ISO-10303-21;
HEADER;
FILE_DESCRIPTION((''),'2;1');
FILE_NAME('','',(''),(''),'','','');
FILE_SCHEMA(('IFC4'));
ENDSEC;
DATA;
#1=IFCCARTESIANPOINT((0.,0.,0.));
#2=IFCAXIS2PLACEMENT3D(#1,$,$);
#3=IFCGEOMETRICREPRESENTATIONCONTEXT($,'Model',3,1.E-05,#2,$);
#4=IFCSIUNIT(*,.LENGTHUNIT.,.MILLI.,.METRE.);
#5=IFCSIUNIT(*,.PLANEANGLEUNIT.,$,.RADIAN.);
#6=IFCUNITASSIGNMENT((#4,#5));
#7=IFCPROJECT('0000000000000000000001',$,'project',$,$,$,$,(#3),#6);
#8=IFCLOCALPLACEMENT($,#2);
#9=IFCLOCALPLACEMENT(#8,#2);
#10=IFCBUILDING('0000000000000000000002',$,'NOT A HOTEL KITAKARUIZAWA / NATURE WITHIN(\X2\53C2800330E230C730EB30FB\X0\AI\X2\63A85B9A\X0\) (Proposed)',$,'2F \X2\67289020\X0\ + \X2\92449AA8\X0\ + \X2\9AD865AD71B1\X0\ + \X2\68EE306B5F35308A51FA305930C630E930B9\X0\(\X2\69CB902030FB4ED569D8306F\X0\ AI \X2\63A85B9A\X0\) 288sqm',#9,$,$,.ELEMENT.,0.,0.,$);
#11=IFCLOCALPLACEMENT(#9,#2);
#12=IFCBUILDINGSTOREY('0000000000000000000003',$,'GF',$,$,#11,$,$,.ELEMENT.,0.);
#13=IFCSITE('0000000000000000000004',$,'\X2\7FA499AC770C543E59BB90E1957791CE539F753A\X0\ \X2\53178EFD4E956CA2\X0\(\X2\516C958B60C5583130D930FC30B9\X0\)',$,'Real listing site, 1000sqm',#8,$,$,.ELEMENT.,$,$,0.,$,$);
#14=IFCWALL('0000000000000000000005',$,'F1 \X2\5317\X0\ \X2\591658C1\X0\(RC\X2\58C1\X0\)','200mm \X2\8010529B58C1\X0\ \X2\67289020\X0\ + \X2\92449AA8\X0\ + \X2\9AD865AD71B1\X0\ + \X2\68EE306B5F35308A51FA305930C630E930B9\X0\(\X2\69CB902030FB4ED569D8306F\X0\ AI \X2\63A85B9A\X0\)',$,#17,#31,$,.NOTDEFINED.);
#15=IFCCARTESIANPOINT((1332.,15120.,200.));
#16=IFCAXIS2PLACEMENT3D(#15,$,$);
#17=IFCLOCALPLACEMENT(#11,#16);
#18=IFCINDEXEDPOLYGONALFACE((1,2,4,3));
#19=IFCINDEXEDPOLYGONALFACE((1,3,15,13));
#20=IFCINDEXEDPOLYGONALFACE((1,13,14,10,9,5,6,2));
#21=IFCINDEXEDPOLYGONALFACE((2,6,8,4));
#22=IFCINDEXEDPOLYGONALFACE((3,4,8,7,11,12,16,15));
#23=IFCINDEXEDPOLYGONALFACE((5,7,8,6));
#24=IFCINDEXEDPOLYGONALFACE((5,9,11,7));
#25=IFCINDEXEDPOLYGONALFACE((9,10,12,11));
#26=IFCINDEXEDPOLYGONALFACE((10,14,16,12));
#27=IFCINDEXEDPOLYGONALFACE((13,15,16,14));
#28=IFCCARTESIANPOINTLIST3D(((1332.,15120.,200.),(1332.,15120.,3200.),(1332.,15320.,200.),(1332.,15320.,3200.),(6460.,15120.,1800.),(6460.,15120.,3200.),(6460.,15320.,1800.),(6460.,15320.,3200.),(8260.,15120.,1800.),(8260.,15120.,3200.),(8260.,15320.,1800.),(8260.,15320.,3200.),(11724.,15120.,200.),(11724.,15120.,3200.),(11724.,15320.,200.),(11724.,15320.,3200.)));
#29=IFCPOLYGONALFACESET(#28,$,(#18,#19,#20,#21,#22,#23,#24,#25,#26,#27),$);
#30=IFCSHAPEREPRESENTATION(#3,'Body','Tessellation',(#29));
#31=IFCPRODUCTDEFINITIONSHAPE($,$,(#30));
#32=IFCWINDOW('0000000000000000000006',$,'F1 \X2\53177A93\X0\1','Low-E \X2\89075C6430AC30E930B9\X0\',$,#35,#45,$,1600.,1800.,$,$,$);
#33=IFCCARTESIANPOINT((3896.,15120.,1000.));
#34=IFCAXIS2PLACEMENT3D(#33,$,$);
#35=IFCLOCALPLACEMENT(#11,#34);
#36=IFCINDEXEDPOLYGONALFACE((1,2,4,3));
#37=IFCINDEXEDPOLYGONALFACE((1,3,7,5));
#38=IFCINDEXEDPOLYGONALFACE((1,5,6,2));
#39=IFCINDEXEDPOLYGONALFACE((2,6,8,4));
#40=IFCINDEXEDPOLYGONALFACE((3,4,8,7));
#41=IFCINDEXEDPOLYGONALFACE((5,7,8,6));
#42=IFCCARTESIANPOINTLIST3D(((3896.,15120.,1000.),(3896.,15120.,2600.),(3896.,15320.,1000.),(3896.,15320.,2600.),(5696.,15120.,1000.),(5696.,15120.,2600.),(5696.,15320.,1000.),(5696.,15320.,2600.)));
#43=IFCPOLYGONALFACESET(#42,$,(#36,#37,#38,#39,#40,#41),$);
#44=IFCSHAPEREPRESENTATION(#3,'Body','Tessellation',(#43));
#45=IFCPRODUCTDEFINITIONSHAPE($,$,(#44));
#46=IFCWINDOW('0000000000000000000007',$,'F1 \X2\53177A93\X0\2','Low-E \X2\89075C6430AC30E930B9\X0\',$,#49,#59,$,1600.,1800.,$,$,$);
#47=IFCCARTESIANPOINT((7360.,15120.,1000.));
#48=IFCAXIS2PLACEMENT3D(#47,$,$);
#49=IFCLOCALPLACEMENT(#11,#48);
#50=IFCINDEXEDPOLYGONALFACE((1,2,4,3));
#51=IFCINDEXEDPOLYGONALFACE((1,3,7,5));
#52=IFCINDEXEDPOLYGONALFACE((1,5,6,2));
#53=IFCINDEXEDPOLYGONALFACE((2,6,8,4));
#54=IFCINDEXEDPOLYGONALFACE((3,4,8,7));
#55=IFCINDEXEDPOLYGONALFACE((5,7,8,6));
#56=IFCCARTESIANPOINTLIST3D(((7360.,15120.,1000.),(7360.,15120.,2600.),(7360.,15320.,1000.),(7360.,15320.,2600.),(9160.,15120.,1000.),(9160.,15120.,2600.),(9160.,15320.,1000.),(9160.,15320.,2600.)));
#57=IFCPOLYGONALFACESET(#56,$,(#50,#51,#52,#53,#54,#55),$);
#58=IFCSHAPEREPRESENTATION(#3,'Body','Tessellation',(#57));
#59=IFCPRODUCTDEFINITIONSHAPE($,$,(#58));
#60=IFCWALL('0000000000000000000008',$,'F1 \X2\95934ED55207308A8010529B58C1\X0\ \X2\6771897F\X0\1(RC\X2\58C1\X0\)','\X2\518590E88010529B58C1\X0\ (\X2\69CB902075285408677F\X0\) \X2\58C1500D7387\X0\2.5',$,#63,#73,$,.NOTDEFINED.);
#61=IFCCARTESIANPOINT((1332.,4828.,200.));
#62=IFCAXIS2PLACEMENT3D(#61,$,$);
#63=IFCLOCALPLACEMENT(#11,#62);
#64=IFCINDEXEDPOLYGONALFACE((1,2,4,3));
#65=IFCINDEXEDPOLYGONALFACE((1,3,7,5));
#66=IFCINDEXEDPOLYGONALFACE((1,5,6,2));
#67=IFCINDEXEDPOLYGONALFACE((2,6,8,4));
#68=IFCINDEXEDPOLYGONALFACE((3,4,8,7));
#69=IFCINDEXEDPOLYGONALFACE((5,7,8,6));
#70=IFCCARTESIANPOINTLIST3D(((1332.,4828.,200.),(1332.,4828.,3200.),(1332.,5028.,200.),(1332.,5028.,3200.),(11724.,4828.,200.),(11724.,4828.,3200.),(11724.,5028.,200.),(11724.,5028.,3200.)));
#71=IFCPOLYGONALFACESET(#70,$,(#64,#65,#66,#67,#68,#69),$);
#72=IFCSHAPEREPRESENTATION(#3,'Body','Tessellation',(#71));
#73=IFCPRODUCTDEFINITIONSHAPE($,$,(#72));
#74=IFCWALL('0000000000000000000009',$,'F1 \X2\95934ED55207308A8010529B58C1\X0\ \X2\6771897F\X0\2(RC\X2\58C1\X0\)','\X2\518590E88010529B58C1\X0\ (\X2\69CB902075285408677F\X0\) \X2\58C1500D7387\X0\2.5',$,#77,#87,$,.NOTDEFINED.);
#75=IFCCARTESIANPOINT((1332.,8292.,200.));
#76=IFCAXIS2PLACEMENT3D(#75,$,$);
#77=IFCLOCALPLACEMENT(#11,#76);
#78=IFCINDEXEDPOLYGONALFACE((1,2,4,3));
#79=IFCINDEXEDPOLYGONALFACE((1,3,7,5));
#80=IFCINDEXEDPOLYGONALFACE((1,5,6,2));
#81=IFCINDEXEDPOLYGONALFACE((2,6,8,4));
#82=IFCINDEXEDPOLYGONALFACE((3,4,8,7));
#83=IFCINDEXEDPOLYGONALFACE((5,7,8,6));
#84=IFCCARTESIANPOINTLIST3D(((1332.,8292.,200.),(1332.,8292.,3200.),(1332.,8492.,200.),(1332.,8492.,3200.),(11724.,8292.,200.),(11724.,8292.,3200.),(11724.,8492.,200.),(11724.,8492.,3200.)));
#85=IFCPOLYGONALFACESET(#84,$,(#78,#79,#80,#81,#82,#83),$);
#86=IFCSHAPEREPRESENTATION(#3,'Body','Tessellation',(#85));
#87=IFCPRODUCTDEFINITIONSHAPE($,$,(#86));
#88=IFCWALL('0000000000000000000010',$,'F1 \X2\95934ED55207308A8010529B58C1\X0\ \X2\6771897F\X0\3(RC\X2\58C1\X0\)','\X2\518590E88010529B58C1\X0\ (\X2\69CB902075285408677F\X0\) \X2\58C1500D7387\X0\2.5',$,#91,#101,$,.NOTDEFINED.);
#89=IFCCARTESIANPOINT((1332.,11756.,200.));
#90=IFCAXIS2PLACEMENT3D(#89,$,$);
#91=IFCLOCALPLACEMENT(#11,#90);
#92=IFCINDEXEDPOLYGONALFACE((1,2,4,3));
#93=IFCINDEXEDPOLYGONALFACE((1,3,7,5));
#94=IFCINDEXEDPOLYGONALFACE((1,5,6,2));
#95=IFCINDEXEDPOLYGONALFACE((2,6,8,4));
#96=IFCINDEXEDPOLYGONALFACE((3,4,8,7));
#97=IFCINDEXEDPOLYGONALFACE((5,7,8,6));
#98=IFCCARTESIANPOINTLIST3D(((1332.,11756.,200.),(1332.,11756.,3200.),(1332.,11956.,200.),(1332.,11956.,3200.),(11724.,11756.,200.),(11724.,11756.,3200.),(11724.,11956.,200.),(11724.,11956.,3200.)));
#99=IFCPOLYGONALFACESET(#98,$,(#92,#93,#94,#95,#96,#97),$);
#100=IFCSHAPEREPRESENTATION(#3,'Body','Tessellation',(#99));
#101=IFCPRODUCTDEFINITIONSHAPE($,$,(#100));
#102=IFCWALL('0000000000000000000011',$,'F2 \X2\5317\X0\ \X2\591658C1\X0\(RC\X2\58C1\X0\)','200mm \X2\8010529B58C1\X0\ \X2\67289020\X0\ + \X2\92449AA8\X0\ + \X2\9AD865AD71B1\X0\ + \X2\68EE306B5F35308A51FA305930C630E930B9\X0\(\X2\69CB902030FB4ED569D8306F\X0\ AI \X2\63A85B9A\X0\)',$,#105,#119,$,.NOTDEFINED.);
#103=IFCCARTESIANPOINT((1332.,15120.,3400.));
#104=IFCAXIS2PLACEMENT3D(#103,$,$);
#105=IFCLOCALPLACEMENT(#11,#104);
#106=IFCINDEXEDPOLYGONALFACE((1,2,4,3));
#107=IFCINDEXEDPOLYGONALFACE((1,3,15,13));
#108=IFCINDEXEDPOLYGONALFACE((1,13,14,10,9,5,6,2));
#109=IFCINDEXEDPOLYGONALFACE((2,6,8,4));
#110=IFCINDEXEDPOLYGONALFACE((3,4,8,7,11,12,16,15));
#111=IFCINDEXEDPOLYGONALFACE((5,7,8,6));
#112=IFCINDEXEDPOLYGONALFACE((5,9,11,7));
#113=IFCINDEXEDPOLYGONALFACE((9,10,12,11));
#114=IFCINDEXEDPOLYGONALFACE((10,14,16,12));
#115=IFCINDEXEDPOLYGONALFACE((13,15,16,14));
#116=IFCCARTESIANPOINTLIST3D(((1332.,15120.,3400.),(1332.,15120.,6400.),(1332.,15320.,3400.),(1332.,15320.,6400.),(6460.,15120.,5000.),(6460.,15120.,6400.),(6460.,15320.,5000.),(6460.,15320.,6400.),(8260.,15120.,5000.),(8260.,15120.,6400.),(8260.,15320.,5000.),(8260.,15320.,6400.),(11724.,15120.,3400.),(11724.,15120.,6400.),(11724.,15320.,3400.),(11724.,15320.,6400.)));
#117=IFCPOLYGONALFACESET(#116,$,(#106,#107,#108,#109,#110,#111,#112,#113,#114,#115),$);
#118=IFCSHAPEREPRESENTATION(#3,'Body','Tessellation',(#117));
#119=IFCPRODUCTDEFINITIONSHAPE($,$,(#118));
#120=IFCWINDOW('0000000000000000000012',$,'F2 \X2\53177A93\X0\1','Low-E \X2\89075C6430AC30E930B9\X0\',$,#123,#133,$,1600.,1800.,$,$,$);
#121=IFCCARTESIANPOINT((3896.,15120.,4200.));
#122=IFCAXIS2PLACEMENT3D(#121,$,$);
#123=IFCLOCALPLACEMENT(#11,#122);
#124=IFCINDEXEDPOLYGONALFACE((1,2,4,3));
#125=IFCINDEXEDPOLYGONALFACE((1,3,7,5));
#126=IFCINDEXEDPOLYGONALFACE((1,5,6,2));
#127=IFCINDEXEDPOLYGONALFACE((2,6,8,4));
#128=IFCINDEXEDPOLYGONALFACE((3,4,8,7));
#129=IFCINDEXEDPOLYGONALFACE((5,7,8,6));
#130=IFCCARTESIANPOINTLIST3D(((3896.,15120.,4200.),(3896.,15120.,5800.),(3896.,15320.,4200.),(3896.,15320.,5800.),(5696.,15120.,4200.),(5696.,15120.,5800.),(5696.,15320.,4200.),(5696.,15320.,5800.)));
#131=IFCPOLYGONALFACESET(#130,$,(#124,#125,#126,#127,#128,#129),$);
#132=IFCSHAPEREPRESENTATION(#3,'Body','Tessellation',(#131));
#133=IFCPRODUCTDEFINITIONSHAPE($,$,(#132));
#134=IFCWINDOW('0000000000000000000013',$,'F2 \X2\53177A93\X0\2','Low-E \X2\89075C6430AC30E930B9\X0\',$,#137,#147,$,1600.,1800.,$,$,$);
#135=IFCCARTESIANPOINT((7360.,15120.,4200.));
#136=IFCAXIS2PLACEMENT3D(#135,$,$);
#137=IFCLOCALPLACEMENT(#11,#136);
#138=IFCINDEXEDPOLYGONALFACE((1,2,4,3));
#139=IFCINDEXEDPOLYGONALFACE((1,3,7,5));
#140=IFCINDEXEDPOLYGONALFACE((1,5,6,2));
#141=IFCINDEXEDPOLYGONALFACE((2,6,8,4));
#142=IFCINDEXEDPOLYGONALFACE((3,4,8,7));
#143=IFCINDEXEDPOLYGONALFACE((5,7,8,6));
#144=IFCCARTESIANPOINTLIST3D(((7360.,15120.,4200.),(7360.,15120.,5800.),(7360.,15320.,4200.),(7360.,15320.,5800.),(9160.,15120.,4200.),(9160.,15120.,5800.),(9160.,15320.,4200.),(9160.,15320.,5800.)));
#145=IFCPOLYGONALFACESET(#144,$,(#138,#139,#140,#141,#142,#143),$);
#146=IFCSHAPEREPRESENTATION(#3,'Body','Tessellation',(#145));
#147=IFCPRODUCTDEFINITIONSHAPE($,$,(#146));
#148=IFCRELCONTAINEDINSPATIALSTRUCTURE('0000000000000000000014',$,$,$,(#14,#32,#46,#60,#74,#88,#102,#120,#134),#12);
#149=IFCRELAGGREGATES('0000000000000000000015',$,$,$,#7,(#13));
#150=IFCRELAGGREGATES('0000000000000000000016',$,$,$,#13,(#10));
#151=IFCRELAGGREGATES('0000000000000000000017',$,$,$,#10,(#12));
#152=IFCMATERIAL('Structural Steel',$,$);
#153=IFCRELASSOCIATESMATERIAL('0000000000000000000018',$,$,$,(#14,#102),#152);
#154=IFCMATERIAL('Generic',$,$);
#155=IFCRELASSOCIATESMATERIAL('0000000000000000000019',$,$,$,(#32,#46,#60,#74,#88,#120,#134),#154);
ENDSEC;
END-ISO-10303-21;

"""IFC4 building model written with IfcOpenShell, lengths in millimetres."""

from ifc_helpers import new_model, si_unit, frame, frame_2d, origin, place, context, project, spatial, rectangle, extrude, material, element, fill, save


model = new_model("IFC4")

# Units and contexts
model_context = context("Model", 3, precision=1e-05, world=origin())
ifc_project = project(units=[si_unit("LENGTHUNIT", "METRE", prefix="MILLI"), si_unit("PLANEANGLEUNIT", "RADIAN")], contexts=[model_context])

# Site, building, storey
site_placement = place(None, origin())
site = spatial("IfcSite", under=ifc_project, at=site_placement, Name="群馬県吾妻郡長野原町 北軽井沢(公開情報ベース)", ObjectType="Real listing site, 1000sqm", CompositionType="ELEMENT", RefElevation=0.0)
building_placement = place(site_placement, origin())
building = spatial("IfcBuilding", under=site, at=building_placement, Name="NOT A HOTEL KITAKARUIZAWA / NATURE WITHIN(参考モデル・AI推定) (Proposed)", ObjectType="2F 木造 + 鉄骨 + 高断熱 + 森に張り出すテラス(構造・仕様は AI 推定) 288sqm", CompositionType="ELEMENT", ElevationOfRefHeight=0.0, ElevationOfTerrain=0.0)
storey_placement = place(building_placement, origin())
storey = spatial("IfcBuildingStorey", under=building, at=storey_placement, Name="GF", CompositionType="ELEMENT", Elevation=0.0)

# Wall, openings, windows
ifc_material_1 = material(Name="Structural Steel")
wall_1_placement = place(storey_placement, frame((1332.0, 15120.0, 200.0)))
wall_1 = element("IfcWall", 1, at=wall_1_placement, inside=storey, material=ifc_material_1, Name="F1 北 外壁(RC壁)", Description="200mm 耐力壁 木造 + 鉄骨 + 高断熱 + 森に張り出すテラス(構造・仕様は AI 推定)", PredefinedType="NOTDEFINED", context=model_context, shape_type="SweptSolid", body=[
    extrude(rectangle(XDim=10392.0, YDim=200.0, at=frame_2d((5196.0, 100.0))), frame((1332.0, 15120.0, 200.0)), (0.0, 0.0, 1.0), 3000.0),
])
opening_1_placement = place(storey_placement, frame((3896.0, 15120.0, 1000.0)))
opening_1 = element("IfcOpeningElement", 2, at=opening_1_placement, cuts=wall_1, PredefinedType="NOTDEFINED", context=model_context, shape_type="SweptSolid", body=[
    extrude(rectangle(XDim=1800.0, YDim=200.0, at=frame_2d((900.0, 100.0))), frame((3896.0, 15120.0, 1000.0)), (0.0, 0.0, 1.0), 1600.0),
])
opening_2_placement = place(storey_placement, frame((7360.0, 15120.0, 1000.0)))
opening_2 = element("IfcOpeningElement", 3, at=opening_2_placement, cuts=wall_1, PredefinedType="NOTDEFINED", context=model_context, shape_type="SweptSolid", body=[
    extrude(rectangle(XDim=1800.0, YDim=200.0, at=frame_2d((900.0, 100.0))), frame((7360.0, 15120.0, 1000.0)), (0.0, 0.0, 1.0), 1600.0),
])
ifc_material_2 = material(Name="Generic")
window_1_placement = place(storey_placement, frame((3896.0, 15120.0, 1000.0)))
window_1 = element("IfcWindow", 4, at=window_1_placement, inside=storey, material=ifc_material_2, Name="F1 北窓1", Description="Low-E 複層ガラス", OverallHeight=1600.0, OverallWidth=1800.0, context=model_context, shape_type="SweptSolid", body=[
    extrude(rectangle(XDim=1800.0, YDim=200.0, at=frame_2d((900.0, 100.0))), frame((3896.0, 15120.0, 1000.0)), (0.0, 0.0, 1.0), 1600.0),
])
fill(opening_1, window_1)
window_2_placement = place(storey_placement, frame((7360.0, 15120.0, 1000.0)))
window_2 = element("IfcWindow", 5, at=window_2_placement, inside=storey, material=ifc_material_2, Name="F1 北窓2", Description="Low-E 複層ガラス", OverallHeight=1600.0, OverallWidth=1800.0, context=model_context, shape_type="SweptSolid", body=[
    extrude(rectangle(XDim=1800.0, YDim=200.0, at=frame_2d((900.0, 100.0))), frame((7360.0, 15120.0, 1000.0)), (0.0, 0.0, 1.0), 1600.0),
])
fill(opening_2, window_2)

# Walls
wall_2_placement = place(storey_placement, frame((1332.0, 4828.0, 200.0)))
element("IfcWall", 6, at=wall_2_placement, inside=storey, material=ifc_material_2, Name="F1 間仕切り耐力壁 東西1(RC壁)", Description="内部耐力壁 (構造用合板) 壁倍率2.5", PredefinedType="NOTDEFINED", context=model_context, shape_type="SweptSolid", body=[
    extrude(rectangle(XDim=10392.0, YDim=200.0, at=frame_2d((5196.0, 100.0))), frame((1332.0, 4828.0, 200.0)), (0.0, 0.0, 1.0), 3000.0),
])
wall_3_placement = place(storey_placement, frame((1332.0, 8292.0, 200.0)))
element("IfcWall", 7, at=wall_3_placement, inside=storey, material=ifc_material_2, Name="F1 間仕切り耐力壁 東西2(RC壁)", Description="内部耐力壁 (構造用合板) 壁倍率2.5", PredefinedType="NOTDEFINED", context=model_context, shape_type="SweptSolid", body=[
    extrude(rectangle(XDim=10392.0, YDim=200.0, at=frame_2d((5196.0, 100.0))), frame((1332.0, 8292.0, 200.0)), (0.0, 0.0, 1.0), 3000.0),
])
wall_4_placement = place(storey_placement, frame((1332.0, 11756.0, 200.0)))
element("IfcWall", 8, at=wall_4_placement, inside=storey, material=ifc_material_2, Name="F1 間仕切り耐力壁 東西3(RC壁)", Description="内部耐力壁 (構造用合板) 壁倍率2.5", PredefinedType="NOTDEFINED", context=model_context, shape_type="SweptSolid", body=[
    extrude(rectangle(XDim=10392.0, YDim=200.0, at=frame_2d((5196.0, 100.0))), frame((1332.0, 11756.0, 200.0)), (0.0, 0.0, 1.0), 3000.0),
])

# Wall, openings, windows
wall_5_placement = place(storey_placement, frame((1332.0, 15120.0, 3400.0)))
wall_5 = element("IfcWall", 9, at=wall_5_placement, inside=storey, material=ifc_material_1, Name="F2 北 外壁(RC壁)", Description="200mm 耐力壁 木造 + 鉄骨 + 高断熱 + 森に張り出すテラス(構造・仕様は AI 推定)", PredefinedType="NOTDEFINED", context=model_context, shape_type="SweptSolid", body=[
    extrude(rectangle(XDim=10392.0, YDim=200.0, at=frame_2d((5196.0, 100.0))), frame((1332.0, 15120.0, 3400.0)), (0.0, 0.0, 1.0), 3000.0),
])
opening_3_placement = place(storey_placement, frame((3896.0, 15120.0, 4200.0)))
opening_3 = element("IfcOpeningElement", 10, at=opening_3_placement, cuts=wall_5, PredefinedType="NOTDEFINED", context=model_context, shape_type="SweptSolid", body=[
    extrude(rectangle(XDim=1800.0, YDim=200.0, at=frame_2d((900.0, 100.0))), frame((3896.0, 15120.0, 4200.0)), (0.0, 0.0, 1.0), 1600.0),
])
opening_4_placement = place(storey_placement, frame((7360.0, 15120.0, 4200.0)))
opening_4 = element("IfcOpeningElement", 11, at=opening_4_placement, cuts=wall_5, PredefinedType="NOTDEFINED", context=model_context, shape_type="SweptSolid", body=[
    extrude(rectangle(XDim=1800.0, YDim=200.0, at=frame_2d((900.0, 100.0))), frame((7360.0, 15120.0, 4200.0)), (0.0, 0.0, 1.0), 1600.0),
])
window_3_placement = place(storey_placement, frame((3896.0, 15120.0, 4200.0)))
window_3 = element("IfcWindow", 12, at=window_3_placement, inside=storey, material=ifc_material_2, Name="F2 北窓1", Description="Low-E 複層ガラス", OverallHeight=1600.0, OverallWidth=1800.0, context=model_context, shape_type="SweptSolid", body=[
    extrude(rectangle(XDim=1800.0, YDim=200.0, at=frame_2d((900.0, 100.0))), frame((3896.0, 15120.0, 4200.0)), (0.0, 0.0, 1.0), 1600.0),
])
fill(opening_3, window_3)
window_4_placement = place(storey_placement, frame((7360.0, 15120.0, 4200.0)))
window_4 = element("IfcWindow", 13, at=window_4_placement, inside=storey, material=ifc_material_2, Name="F2 北窓2", Description="Low-E 複層ガラス", OverallHeight=1600.0, OverallWidth=1800.0, context=model_context, shape_type="SweptSolid", body=[
    extrude(rectangle(XDim=1800.0, YDim=200.0, at=frame_2d((900.0, 100.0))), frame((7360.0, 15120.0, 4200.0)), (0.0, 0.0, 1.0), 1600.0),
])
fill(opening_4, window_4)

save(model, "model.ifc")
